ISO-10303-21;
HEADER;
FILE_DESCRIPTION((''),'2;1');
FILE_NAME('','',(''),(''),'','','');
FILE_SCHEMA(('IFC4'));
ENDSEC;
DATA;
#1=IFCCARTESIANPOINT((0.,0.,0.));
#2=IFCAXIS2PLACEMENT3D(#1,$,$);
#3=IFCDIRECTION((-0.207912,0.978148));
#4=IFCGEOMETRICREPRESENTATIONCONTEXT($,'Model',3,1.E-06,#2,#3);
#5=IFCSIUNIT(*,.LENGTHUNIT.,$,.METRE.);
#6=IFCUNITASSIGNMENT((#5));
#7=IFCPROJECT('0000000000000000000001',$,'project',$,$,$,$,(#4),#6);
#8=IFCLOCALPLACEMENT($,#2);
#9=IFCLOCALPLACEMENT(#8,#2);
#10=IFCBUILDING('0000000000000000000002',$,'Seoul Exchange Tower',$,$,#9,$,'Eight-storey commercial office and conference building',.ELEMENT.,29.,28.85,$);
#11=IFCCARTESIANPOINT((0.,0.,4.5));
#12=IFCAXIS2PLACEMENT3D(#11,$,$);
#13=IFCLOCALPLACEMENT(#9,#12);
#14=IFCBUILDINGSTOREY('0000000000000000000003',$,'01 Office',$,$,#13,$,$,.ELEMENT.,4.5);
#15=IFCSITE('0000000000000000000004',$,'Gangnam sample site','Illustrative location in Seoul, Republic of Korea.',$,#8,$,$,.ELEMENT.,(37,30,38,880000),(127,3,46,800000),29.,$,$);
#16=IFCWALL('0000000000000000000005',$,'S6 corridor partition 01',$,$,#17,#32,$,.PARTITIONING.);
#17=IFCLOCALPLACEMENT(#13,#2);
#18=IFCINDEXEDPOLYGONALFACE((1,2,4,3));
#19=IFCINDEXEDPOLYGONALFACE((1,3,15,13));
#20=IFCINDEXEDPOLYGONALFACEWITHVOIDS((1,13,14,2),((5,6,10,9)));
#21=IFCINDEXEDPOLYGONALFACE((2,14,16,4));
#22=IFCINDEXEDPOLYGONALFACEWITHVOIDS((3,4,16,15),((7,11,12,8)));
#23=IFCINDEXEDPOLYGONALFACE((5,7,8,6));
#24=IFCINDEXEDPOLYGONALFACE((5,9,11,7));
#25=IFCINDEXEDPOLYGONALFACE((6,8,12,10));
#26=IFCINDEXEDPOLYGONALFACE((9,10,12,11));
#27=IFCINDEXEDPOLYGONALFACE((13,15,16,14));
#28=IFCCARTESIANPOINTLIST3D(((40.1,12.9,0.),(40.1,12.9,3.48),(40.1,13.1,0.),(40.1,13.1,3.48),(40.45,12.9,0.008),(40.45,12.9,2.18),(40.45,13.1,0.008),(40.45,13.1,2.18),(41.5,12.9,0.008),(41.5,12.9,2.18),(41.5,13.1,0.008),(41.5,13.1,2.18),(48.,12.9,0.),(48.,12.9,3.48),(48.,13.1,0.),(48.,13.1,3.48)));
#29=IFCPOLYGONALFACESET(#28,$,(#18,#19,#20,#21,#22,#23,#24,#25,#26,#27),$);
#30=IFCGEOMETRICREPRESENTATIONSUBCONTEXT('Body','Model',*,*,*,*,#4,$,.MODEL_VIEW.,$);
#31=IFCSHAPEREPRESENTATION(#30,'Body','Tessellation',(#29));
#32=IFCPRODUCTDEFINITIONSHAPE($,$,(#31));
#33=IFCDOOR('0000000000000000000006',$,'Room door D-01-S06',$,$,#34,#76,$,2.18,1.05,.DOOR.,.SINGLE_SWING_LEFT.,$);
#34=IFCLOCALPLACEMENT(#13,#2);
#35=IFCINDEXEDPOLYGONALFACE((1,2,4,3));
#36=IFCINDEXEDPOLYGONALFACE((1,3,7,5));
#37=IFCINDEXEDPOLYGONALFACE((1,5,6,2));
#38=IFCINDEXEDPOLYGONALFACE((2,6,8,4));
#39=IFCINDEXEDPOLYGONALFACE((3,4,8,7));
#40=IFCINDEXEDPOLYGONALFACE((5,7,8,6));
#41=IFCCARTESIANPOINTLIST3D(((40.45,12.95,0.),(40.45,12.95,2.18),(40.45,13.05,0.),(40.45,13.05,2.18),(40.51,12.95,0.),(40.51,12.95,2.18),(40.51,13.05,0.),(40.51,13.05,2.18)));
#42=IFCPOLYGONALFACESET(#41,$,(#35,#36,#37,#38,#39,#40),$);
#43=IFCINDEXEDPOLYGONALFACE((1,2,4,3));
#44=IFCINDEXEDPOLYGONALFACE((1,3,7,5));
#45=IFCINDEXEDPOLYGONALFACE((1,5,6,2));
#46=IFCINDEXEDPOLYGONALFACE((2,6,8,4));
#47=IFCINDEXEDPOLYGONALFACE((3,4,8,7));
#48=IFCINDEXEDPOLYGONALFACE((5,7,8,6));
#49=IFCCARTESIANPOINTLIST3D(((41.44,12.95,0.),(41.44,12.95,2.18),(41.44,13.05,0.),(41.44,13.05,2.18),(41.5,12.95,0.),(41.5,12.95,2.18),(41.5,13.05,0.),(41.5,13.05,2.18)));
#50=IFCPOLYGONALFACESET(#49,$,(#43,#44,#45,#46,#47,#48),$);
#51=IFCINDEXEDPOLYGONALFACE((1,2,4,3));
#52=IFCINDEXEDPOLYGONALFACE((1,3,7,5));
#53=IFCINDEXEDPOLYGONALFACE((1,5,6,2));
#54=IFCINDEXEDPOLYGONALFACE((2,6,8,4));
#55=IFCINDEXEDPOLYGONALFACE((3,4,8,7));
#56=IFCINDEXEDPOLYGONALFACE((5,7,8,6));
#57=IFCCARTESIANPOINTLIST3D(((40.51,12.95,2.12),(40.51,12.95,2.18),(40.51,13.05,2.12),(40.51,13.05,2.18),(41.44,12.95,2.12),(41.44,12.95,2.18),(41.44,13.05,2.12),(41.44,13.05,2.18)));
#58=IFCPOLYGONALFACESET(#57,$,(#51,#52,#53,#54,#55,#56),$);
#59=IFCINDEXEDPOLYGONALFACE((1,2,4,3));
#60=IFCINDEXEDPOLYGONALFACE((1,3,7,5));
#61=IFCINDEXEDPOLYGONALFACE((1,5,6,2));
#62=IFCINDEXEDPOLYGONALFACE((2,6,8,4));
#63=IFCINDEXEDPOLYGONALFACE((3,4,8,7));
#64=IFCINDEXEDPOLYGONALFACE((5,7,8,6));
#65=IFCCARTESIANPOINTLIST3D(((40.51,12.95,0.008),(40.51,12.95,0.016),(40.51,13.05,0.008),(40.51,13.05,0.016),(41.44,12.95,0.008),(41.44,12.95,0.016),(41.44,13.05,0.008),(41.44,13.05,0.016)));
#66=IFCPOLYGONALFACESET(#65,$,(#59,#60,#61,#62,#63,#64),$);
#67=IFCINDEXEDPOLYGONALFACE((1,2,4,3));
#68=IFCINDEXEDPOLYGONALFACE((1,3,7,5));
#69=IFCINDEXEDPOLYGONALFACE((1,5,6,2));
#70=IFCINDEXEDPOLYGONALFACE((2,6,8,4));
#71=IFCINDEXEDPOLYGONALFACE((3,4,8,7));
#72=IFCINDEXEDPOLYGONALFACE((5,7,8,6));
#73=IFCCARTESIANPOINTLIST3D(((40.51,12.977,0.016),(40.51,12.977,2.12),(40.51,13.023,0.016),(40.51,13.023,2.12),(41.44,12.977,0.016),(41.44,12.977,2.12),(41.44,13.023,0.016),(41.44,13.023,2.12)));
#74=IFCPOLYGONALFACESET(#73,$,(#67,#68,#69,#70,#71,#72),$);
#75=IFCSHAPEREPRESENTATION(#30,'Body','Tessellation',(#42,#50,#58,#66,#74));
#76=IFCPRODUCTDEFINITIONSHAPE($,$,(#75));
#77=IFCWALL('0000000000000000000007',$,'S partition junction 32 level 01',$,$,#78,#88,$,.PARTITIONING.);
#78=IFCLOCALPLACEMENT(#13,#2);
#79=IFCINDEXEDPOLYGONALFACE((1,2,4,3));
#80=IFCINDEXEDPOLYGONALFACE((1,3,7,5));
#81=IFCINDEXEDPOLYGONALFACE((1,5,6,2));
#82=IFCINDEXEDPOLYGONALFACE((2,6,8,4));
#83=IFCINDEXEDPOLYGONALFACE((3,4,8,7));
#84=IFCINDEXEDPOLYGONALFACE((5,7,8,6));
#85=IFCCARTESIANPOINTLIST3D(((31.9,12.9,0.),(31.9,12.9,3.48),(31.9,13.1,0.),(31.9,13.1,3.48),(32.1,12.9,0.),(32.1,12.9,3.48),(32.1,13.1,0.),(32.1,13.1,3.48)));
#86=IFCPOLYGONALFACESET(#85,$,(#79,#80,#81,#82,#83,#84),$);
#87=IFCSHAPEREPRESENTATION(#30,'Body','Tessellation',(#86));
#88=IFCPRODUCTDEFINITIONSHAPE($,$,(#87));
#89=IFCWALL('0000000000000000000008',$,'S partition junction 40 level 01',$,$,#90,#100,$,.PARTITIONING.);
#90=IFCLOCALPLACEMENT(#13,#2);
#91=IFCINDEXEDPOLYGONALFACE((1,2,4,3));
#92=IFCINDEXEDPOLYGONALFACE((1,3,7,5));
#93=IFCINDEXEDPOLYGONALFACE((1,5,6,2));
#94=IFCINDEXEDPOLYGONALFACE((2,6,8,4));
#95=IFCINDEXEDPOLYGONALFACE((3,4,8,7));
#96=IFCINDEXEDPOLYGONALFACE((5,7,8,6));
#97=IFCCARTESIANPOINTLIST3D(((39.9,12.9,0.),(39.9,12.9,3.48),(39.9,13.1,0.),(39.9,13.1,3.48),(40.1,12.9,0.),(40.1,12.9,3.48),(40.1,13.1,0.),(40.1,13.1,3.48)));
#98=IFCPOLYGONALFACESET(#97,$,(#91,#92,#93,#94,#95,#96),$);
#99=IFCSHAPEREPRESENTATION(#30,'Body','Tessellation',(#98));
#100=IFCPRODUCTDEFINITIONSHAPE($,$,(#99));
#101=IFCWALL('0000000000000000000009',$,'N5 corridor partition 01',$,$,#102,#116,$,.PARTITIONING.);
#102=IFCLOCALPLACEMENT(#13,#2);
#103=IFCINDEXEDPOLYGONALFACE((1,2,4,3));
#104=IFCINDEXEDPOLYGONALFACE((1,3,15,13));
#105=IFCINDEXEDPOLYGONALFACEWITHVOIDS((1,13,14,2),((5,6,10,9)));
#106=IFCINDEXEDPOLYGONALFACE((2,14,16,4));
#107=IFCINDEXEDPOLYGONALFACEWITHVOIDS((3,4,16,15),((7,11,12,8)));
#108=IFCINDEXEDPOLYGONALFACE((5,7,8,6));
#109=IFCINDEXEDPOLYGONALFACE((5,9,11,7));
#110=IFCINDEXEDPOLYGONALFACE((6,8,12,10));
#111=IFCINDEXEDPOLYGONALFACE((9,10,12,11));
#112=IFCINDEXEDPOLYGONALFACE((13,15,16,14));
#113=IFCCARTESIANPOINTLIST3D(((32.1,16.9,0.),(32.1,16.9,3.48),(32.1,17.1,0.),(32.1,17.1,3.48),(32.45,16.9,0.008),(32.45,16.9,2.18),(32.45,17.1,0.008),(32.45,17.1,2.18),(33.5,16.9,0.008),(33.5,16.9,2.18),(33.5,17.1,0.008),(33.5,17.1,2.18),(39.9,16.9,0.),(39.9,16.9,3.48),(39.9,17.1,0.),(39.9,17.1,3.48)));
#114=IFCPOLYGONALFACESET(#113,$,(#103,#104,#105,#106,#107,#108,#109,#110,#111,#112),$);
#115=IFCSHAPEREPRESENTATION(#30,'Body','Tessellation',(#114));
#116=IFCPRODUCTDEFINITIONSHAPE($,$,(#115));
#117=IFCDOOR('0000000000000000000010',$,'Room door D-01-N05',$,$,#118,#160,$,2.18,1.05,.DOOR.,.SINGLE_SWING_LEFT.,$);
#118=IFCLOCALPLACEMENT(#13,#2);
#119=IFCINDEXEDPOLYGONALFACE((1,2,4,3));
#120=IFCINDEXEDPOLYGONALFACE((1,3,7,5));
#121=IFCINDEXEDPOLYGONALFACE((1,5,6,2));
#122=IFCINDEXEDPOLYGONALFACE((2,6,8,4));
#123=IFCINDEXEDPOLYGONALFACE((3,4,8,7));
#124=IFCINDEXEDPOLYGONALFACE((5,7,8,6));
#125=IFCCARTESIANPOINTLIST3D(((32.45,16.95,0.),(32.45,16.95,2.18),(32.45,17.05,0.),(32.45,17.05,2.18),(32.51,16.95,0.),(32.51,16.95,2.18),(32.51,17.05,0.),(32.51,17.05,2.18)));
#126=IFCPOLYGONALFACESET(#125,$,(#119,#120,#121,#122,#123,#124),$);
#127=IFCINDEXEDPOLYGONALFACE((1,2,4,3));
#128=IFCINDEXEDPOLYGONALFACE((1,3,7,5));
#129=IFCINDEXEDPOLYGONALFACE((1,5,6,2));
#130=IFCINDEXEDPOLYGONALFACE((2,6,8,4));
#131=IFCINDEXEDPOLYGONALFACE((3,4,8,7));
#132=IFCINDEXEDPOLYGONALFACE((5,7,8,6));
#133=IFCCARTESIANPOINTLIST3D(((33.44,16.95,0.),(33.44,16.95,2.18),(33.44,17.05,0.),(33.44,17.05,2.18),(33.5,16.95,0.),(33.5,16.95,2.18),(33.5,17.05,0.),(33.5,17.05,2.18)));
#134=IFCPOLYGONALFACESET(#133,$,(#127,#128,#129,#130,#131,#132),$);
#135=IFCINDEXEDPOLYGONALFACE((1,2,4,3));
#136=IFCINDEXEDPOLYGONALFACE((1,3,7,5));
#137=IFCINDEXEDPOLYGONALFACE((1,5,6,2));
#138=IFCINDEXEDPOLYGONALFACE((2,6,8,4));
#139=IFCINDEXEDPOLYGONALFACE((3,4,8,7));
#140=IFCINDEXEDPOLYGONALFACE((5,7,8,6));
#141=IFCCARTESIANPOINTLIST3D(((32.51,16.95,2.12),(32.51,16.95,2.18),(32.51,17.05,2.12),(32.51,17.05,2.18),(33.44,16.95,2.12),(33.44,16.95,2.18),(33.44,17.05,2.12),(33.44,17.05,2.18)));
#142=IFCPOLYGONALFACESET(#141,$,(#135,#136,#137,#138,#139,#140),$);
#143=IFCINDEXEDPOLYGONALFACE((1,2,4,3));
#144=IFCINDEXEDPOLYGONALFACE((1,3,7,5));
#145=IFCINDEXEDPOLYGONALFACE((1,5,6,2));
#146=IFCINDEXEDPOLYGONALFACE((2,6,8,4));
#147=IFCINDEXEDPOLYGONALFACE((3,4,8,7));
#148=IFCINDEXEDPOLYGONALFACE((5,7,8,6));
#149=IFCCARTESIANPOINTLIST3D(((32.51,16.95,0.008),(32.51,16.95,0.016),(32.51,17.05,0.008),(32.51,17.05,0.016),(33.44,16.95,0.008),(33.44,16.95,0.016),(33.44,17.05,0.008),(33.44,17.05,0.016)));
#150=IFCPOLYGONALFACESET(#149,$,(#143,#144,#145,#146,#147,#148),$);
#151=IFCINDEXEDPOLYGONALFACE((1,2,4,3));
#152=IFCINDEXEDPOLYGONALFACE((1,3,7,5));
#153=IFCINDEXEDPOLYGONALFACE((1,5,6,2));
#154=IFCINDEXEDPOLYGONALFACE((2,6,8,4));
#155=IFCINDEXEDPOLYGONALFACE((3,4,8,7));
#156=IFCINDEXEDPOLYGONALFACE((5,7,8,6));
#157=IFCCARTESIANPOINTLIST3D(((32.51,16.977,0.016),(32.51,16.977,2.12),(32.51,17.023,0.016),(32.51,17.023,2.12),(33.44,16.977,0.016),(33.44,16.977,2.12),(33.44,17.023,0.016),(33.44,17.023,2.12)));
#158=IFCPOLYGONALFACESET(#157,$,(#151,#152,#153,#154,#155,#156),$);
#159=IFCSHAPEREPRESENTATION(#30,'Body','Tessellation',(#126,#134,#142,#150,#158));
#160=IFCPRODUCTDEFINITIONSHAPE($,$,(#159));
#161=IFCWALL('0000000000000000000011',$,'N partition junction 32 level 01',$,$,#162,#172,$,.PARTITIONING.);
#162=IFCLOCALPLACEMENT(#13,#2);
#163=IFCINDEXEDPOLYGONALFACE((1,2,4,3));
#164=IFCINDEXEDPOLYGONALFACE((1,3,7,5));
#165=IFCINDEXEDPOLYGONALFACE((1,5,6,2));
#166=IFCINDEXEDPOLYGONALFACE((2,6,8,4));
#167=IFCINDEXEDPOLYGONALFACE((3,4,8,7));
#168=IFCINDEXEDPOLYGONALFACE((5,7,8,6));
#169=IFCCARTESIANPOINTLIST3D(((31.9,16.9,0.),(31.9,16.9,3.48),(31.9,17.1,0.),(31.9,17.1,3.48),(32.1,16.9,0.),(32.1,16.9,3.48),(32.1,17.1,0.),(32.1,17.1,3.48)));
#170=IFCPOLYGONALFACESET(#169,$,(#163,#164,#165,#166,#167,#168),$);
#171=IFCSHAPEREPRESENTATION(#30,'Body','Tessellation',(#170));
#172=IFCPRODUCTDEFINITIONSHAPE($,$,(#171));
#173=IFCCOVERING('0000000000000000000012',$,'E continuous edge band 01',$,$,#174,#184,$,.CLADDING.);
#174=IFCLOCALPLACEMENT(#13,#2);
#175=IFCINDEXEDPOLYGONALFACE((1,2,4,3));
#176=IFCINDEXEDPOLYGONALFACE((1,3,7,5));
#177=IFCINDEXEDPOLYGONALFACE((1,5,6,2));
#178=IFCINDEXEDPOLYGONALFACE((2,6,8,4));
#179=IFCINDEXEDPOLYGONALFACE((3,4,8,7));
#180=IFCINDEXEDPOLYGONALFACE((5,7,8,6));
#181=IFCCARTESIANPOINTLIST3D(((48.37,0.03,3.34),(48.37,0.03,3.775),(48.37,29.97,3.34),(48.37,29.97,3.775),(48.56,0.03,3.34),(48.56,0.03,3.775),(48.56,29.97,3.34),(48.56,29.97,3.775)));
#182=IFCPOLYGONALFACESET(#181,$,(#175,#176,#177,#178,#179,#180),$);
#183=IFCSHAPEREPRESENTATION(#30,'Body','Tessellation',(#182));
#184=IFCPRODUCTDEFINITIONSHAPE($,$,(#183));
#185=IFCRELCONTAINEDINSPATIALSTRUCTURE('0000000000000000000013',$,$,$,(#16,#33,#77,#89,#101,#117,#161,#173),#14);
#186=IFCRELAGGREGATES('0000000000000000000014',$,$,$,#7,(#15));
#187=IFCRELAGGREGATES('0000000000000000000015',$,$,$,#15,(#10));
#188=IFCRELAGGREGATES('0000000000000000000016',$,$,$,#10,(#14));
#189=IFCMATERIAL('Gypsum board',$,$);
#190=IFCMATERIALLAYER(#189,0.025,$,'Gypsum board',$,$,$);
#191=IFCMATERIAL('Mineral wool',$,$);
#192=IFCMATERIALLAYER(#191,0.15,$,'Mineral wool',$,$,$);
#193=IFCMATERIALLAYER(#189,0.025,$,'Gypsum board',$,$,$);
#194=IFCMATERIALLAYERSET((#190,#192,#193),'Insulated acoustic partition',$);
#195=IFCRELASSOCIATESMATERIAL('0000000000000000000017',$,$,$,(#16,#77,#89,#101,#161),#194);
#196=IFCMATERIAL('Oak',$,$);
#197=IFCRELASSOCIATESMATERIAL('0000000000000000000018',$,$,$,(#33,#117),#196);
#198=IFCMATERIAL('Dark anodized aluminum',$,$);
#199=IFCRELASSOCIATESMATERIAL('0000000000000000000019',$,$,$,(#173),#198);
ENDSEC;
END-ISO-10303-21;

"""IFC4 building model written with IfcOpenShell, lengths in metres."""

from ifc_helpers import new_model, si_unit, direction, frame, frame_2d, origin, place, context, subcontext, project, spatial, rectangle, extrude, material, layer, layer_set, layer_usage, element, fill, save


model = new_model("IFC4")

# Units and contexts
model_context = context("Model", 3, precision=1e-06, world=origin(), true_north=direction((-0.207912, 0.978148)))
body_context = subcontext(model_context, "Body", "Model", "MODEL_VIEW")
ifc_project = project(units=[si_unit("LENGTHUNIT", "METRE")], contexts=[model_context])

# Site, building, storey
site_placement = place(None, origin())
site = spatial("IfcSite", under=ifc_project, at=site_placement, Name="Gangnam sample site", Description="Illustrative location in Seoul, Republic of Korea.", CompositionType="ELEMENT", RefLatitude=(37, 30, 38, 880000), RefLongitude=(127, 3, 46, 800000), RefElevation=29.0)
building_placement = place(site_placement, origin())
building = spatial("IfcBuilding", under=site, at=building_placement, Name="Seoul Exchange Tower", LongName="Eight-storey commercial office and conference building", CompositionType="ELEMENT", ElevationOfRefHeight=29.0, ElevationOfTerrain=28.85)
storey_placement = place(building_placement, frame((0.0, 0.0, 4.5)))
storey = spatial("IfcBuildingStorey", under=building, at=storey_placement, Name="01 Office", CompositionType="ELEMENT", Elevation=4.5)

# Shared definitions
wall_1_placement = place(storey_placement, frame((48.4, 0.0, 0.0), z_axis=(0.0, 0.0, 1.0), x_axis=(0.0, 1.0, 0.0)))
placement_1 = place(wall_1_placement, origin())

# Shared definitions
ifc_material_1 = material(Name="Mineral wool")
ifc_material_2 = material(Name="Gypsum board")
ifc_material_3 = material(Name="Dark anodized aluminum")

# Shared definitions
ifc_layer_1 = layer(ifc_material_2, 0.025, Name="Gypsum board")
ifc_layer_2 = layer(ifc_material_1, 0.15, Name="Mineral wool")
ifc_layer_3 = layer(ifc_material_2, 0.025, Name="Gypsum board")
ifc_layer_set_1 = layer_set([ifc_layer_1, ifc_layer_2, ifc_layer_3], Name="Insulated acoustic partition")
ifc_layer_usage_1 = layer_usage(ifc_layer_set_1, "AXIS2", "POSITIVE", 0.0)

# Shared definitions
ifc_material_4 = material(Name="Oak")

# Wall, opening, door
wall_2_placement = place(storey_placement, frame((40.1, 12.9, 0.0)))
wall_2 = element("IfcWall", 1, at=wall_2_placement, inside=storey, material=ifc_layer_usage_1, Name="S6 corridor partition 01", PredefinedType="PARTITIONING", context=body_context, shape_type="SweptSolid", body=[
    extrude(rectangle(XDim=7.9, YDim=0.2, at=frame_2d((3.95, 0.1))), origin(), (0.0, 0.0, 1.0), 3.48),
])
placement_2 = place(wall_2_placement, origin())
opening_1 = element("IfcOpeningElement", 2, at=placement_2, cuts=wall_2, PredefinedType="OPENING", context=body_context, shape_type="SweptSolid", body=[
    extrude(rectangle(XDim=1.05, YDim=0.24, at=frame_2d((0.525, 0.12))), frame((0.35, -0.02, 0.008)), (0.0, 0.0, 1.0), 2.172),
])
door_1 = element("IfcDoor", 3, at=placement_2, inside=storey, material=ifc_material_4, Name="Room door D-01-S06", OperationType="SINGLE_SWING_LEFT", OverallHeight=2.18, OverallWidth=1.05, PredefinedType="DOOR", context=body_context, shape_type="SweptSolid", body=[
    extrude(rectangle(XDim=0.06, YDim=0.1, at=frame_2d((0.03, 0.05))), frame((0.35, 0.05, 0.0)), (0.0, 0.0, 1.0), 2.18),
    extrude(rectangle(XDim=0.06, YDim=0.1, at=frame_2d((0.03, 0.05))), frame((1.34, 0.05, 0.0)), (0.0, 0.0, 1.0), 2.18),
    extrude(rectangle(XDim=0.93, YDim=0.1, at=frame_2d((0.465, 0.05))), frame((0.41, 0.05, 2.12)), (0.0, 0.0, 1.0), 0.06),
    extrude(rectangle(XDim=0.93, YDim=0.1, at=frame_2d((0.465, 0.05))), frame((0.41, 0.05, 0.008)), (0.0, 0.0, 1.0), 0.008),
    extrude(rectangle(XDim=0.93, YDim=0.046, at=frame_2d((0.465, 0.023))), frame((0.41, 0.077, 0.016)), (0.0, 0.0, 1.0), 2.104),
])
fill(opening_1, door_1)

# Walls
for number, where, name in (
    (4, (31.9, 12.9, 0.0), "S partition junction 32 level 01"),
    (5, (39.9, 12.9, 0.0), "S partition junction 40 level 01"),
):
    element("IfcWall", number, at=place(storey_placement, frame(where)), inside=storey, material=ifc_layer_usage_1, Name=name, PredefinedType="PARTITIONING", context=body_context, shape_type="SweptSolid", body=[
        extrude(rectangle(XDim=0.2, YDim=0.2, at=frame_2d((0.1, 0.1))), origin(), (0.0, 0.0, 1.0), 3.48),
    ])

# Wall, opening, door
wall_3_placement = place(storey_placement, frame((32.1, 16.9, 0.0)))
wall_3 = element("IfcWall", 6, at=wall_3_placement, inside=storey, material=ifc_layer_usage_1, Name="N5 corridor partition 01", PredefinedType="PARTITIONING", context=body_context, shape_type="SweptSolid", body=[
    extrude(rectangle(XDim=7.8, YDim=0.2, at=frame_2d((3.9, 0.1))), origin(), (0.0, 0.0, 1.0), 3.48),
])
placement_3 = place(wall_3_placement, origin())
opening_2 = element("IfcOpeningElement", 7, at=placement_3, cuts=wall_3, PredefinedType="OPENING", context=body_context, shape_type="SweptSolid", body=[
    extrude(rectangle(XDim=1.05, YDim=0.24, at=frame_2d((0.525, 0.12))), frame((0.35, -0.02, 0.008)), (0.0, 0.0, 1.0), 2.172),
])
door_2 = element("IfcDoor", 8, at=placement_3, inside=storey, material=ifc_material_4, Name="Room door D-01-N05", OperationType="SINGLE_SWING_LEFT", OverallHeight=2.18, OverallWidth=1.05, PredefinedType="DOOR", context=body_context, shape_type="SweptSolid", body=[
    extrude(rectangle(XDim=0.06, YDim=0.1, at=frame_2d((0.03, 0.05))), frame((0.35, 0.05, 0.0)), (0.0, 0.0, 1.0), 2.18),
    extrude(rectangle(XDim=0.06, YDim=0.1, at=frame_2d((0.03, 0.05))), frame((1.34, 0.05, 0.0)), (0.0, 0.0, 1.0), 2.18),
    extrude(rectangle(XDim=0.93, YDim=0.1, at=frame_2d((0.465, 0.05))), frame((0.41, 0.05, 2.12)), (0.0, 0.0, 1.0), 0.06),
    extrude(rectangle(XDim=0.93, YDim=0.1, at=frame_2d((0.465, 0.05))), frame((0.41, 0.05, 0.008)), (0.0, 0.0, 1.0), 0.008),
    extrude(rectangle(XDim=0.93, YDim=0.046, at=frame_2d((0.465, 0.023))), frame((0.41, 0.077, 0.016)), (0.0, 0.0, 1.0), 2.104),
])
fill(opening_2, door_2)

# Wall
wall_4_placement = place(storey_placement, frame((31.9, 16.9, 0.0)))
element("IfcWall", 9, at=wall_4_placement, inside=storey, material=ifc_layer_usage_1, Name="N partition junction 32 level 01", PredefinedType="PARTITIONING", context=body_context, shape_type="SweptSolid", body=[
    extrude(rectangle(XDim=0.2, YDim=0.2, at=frame_2d((0.1, 0.1))), origin(), (0.0, 0.0, 1.0), 3.48),
])

# Covering
element("IfcCovering", 10, at=placement_1, inside=storey, material=ifc_material_3, Name="E continuous edge band 01", PredefinedType="CLADDING", context=body_context, shape_type="SweptSolid", body=[
    extrude(rectangle(XDim=29.94, YDim=0.19, at=frame_2d((14.97, 0.095))), frame((0.03, -0.16, 3.34)), (0.0, 0.0, 1.0), 0.435),
])

save(model, "model.ifc")
